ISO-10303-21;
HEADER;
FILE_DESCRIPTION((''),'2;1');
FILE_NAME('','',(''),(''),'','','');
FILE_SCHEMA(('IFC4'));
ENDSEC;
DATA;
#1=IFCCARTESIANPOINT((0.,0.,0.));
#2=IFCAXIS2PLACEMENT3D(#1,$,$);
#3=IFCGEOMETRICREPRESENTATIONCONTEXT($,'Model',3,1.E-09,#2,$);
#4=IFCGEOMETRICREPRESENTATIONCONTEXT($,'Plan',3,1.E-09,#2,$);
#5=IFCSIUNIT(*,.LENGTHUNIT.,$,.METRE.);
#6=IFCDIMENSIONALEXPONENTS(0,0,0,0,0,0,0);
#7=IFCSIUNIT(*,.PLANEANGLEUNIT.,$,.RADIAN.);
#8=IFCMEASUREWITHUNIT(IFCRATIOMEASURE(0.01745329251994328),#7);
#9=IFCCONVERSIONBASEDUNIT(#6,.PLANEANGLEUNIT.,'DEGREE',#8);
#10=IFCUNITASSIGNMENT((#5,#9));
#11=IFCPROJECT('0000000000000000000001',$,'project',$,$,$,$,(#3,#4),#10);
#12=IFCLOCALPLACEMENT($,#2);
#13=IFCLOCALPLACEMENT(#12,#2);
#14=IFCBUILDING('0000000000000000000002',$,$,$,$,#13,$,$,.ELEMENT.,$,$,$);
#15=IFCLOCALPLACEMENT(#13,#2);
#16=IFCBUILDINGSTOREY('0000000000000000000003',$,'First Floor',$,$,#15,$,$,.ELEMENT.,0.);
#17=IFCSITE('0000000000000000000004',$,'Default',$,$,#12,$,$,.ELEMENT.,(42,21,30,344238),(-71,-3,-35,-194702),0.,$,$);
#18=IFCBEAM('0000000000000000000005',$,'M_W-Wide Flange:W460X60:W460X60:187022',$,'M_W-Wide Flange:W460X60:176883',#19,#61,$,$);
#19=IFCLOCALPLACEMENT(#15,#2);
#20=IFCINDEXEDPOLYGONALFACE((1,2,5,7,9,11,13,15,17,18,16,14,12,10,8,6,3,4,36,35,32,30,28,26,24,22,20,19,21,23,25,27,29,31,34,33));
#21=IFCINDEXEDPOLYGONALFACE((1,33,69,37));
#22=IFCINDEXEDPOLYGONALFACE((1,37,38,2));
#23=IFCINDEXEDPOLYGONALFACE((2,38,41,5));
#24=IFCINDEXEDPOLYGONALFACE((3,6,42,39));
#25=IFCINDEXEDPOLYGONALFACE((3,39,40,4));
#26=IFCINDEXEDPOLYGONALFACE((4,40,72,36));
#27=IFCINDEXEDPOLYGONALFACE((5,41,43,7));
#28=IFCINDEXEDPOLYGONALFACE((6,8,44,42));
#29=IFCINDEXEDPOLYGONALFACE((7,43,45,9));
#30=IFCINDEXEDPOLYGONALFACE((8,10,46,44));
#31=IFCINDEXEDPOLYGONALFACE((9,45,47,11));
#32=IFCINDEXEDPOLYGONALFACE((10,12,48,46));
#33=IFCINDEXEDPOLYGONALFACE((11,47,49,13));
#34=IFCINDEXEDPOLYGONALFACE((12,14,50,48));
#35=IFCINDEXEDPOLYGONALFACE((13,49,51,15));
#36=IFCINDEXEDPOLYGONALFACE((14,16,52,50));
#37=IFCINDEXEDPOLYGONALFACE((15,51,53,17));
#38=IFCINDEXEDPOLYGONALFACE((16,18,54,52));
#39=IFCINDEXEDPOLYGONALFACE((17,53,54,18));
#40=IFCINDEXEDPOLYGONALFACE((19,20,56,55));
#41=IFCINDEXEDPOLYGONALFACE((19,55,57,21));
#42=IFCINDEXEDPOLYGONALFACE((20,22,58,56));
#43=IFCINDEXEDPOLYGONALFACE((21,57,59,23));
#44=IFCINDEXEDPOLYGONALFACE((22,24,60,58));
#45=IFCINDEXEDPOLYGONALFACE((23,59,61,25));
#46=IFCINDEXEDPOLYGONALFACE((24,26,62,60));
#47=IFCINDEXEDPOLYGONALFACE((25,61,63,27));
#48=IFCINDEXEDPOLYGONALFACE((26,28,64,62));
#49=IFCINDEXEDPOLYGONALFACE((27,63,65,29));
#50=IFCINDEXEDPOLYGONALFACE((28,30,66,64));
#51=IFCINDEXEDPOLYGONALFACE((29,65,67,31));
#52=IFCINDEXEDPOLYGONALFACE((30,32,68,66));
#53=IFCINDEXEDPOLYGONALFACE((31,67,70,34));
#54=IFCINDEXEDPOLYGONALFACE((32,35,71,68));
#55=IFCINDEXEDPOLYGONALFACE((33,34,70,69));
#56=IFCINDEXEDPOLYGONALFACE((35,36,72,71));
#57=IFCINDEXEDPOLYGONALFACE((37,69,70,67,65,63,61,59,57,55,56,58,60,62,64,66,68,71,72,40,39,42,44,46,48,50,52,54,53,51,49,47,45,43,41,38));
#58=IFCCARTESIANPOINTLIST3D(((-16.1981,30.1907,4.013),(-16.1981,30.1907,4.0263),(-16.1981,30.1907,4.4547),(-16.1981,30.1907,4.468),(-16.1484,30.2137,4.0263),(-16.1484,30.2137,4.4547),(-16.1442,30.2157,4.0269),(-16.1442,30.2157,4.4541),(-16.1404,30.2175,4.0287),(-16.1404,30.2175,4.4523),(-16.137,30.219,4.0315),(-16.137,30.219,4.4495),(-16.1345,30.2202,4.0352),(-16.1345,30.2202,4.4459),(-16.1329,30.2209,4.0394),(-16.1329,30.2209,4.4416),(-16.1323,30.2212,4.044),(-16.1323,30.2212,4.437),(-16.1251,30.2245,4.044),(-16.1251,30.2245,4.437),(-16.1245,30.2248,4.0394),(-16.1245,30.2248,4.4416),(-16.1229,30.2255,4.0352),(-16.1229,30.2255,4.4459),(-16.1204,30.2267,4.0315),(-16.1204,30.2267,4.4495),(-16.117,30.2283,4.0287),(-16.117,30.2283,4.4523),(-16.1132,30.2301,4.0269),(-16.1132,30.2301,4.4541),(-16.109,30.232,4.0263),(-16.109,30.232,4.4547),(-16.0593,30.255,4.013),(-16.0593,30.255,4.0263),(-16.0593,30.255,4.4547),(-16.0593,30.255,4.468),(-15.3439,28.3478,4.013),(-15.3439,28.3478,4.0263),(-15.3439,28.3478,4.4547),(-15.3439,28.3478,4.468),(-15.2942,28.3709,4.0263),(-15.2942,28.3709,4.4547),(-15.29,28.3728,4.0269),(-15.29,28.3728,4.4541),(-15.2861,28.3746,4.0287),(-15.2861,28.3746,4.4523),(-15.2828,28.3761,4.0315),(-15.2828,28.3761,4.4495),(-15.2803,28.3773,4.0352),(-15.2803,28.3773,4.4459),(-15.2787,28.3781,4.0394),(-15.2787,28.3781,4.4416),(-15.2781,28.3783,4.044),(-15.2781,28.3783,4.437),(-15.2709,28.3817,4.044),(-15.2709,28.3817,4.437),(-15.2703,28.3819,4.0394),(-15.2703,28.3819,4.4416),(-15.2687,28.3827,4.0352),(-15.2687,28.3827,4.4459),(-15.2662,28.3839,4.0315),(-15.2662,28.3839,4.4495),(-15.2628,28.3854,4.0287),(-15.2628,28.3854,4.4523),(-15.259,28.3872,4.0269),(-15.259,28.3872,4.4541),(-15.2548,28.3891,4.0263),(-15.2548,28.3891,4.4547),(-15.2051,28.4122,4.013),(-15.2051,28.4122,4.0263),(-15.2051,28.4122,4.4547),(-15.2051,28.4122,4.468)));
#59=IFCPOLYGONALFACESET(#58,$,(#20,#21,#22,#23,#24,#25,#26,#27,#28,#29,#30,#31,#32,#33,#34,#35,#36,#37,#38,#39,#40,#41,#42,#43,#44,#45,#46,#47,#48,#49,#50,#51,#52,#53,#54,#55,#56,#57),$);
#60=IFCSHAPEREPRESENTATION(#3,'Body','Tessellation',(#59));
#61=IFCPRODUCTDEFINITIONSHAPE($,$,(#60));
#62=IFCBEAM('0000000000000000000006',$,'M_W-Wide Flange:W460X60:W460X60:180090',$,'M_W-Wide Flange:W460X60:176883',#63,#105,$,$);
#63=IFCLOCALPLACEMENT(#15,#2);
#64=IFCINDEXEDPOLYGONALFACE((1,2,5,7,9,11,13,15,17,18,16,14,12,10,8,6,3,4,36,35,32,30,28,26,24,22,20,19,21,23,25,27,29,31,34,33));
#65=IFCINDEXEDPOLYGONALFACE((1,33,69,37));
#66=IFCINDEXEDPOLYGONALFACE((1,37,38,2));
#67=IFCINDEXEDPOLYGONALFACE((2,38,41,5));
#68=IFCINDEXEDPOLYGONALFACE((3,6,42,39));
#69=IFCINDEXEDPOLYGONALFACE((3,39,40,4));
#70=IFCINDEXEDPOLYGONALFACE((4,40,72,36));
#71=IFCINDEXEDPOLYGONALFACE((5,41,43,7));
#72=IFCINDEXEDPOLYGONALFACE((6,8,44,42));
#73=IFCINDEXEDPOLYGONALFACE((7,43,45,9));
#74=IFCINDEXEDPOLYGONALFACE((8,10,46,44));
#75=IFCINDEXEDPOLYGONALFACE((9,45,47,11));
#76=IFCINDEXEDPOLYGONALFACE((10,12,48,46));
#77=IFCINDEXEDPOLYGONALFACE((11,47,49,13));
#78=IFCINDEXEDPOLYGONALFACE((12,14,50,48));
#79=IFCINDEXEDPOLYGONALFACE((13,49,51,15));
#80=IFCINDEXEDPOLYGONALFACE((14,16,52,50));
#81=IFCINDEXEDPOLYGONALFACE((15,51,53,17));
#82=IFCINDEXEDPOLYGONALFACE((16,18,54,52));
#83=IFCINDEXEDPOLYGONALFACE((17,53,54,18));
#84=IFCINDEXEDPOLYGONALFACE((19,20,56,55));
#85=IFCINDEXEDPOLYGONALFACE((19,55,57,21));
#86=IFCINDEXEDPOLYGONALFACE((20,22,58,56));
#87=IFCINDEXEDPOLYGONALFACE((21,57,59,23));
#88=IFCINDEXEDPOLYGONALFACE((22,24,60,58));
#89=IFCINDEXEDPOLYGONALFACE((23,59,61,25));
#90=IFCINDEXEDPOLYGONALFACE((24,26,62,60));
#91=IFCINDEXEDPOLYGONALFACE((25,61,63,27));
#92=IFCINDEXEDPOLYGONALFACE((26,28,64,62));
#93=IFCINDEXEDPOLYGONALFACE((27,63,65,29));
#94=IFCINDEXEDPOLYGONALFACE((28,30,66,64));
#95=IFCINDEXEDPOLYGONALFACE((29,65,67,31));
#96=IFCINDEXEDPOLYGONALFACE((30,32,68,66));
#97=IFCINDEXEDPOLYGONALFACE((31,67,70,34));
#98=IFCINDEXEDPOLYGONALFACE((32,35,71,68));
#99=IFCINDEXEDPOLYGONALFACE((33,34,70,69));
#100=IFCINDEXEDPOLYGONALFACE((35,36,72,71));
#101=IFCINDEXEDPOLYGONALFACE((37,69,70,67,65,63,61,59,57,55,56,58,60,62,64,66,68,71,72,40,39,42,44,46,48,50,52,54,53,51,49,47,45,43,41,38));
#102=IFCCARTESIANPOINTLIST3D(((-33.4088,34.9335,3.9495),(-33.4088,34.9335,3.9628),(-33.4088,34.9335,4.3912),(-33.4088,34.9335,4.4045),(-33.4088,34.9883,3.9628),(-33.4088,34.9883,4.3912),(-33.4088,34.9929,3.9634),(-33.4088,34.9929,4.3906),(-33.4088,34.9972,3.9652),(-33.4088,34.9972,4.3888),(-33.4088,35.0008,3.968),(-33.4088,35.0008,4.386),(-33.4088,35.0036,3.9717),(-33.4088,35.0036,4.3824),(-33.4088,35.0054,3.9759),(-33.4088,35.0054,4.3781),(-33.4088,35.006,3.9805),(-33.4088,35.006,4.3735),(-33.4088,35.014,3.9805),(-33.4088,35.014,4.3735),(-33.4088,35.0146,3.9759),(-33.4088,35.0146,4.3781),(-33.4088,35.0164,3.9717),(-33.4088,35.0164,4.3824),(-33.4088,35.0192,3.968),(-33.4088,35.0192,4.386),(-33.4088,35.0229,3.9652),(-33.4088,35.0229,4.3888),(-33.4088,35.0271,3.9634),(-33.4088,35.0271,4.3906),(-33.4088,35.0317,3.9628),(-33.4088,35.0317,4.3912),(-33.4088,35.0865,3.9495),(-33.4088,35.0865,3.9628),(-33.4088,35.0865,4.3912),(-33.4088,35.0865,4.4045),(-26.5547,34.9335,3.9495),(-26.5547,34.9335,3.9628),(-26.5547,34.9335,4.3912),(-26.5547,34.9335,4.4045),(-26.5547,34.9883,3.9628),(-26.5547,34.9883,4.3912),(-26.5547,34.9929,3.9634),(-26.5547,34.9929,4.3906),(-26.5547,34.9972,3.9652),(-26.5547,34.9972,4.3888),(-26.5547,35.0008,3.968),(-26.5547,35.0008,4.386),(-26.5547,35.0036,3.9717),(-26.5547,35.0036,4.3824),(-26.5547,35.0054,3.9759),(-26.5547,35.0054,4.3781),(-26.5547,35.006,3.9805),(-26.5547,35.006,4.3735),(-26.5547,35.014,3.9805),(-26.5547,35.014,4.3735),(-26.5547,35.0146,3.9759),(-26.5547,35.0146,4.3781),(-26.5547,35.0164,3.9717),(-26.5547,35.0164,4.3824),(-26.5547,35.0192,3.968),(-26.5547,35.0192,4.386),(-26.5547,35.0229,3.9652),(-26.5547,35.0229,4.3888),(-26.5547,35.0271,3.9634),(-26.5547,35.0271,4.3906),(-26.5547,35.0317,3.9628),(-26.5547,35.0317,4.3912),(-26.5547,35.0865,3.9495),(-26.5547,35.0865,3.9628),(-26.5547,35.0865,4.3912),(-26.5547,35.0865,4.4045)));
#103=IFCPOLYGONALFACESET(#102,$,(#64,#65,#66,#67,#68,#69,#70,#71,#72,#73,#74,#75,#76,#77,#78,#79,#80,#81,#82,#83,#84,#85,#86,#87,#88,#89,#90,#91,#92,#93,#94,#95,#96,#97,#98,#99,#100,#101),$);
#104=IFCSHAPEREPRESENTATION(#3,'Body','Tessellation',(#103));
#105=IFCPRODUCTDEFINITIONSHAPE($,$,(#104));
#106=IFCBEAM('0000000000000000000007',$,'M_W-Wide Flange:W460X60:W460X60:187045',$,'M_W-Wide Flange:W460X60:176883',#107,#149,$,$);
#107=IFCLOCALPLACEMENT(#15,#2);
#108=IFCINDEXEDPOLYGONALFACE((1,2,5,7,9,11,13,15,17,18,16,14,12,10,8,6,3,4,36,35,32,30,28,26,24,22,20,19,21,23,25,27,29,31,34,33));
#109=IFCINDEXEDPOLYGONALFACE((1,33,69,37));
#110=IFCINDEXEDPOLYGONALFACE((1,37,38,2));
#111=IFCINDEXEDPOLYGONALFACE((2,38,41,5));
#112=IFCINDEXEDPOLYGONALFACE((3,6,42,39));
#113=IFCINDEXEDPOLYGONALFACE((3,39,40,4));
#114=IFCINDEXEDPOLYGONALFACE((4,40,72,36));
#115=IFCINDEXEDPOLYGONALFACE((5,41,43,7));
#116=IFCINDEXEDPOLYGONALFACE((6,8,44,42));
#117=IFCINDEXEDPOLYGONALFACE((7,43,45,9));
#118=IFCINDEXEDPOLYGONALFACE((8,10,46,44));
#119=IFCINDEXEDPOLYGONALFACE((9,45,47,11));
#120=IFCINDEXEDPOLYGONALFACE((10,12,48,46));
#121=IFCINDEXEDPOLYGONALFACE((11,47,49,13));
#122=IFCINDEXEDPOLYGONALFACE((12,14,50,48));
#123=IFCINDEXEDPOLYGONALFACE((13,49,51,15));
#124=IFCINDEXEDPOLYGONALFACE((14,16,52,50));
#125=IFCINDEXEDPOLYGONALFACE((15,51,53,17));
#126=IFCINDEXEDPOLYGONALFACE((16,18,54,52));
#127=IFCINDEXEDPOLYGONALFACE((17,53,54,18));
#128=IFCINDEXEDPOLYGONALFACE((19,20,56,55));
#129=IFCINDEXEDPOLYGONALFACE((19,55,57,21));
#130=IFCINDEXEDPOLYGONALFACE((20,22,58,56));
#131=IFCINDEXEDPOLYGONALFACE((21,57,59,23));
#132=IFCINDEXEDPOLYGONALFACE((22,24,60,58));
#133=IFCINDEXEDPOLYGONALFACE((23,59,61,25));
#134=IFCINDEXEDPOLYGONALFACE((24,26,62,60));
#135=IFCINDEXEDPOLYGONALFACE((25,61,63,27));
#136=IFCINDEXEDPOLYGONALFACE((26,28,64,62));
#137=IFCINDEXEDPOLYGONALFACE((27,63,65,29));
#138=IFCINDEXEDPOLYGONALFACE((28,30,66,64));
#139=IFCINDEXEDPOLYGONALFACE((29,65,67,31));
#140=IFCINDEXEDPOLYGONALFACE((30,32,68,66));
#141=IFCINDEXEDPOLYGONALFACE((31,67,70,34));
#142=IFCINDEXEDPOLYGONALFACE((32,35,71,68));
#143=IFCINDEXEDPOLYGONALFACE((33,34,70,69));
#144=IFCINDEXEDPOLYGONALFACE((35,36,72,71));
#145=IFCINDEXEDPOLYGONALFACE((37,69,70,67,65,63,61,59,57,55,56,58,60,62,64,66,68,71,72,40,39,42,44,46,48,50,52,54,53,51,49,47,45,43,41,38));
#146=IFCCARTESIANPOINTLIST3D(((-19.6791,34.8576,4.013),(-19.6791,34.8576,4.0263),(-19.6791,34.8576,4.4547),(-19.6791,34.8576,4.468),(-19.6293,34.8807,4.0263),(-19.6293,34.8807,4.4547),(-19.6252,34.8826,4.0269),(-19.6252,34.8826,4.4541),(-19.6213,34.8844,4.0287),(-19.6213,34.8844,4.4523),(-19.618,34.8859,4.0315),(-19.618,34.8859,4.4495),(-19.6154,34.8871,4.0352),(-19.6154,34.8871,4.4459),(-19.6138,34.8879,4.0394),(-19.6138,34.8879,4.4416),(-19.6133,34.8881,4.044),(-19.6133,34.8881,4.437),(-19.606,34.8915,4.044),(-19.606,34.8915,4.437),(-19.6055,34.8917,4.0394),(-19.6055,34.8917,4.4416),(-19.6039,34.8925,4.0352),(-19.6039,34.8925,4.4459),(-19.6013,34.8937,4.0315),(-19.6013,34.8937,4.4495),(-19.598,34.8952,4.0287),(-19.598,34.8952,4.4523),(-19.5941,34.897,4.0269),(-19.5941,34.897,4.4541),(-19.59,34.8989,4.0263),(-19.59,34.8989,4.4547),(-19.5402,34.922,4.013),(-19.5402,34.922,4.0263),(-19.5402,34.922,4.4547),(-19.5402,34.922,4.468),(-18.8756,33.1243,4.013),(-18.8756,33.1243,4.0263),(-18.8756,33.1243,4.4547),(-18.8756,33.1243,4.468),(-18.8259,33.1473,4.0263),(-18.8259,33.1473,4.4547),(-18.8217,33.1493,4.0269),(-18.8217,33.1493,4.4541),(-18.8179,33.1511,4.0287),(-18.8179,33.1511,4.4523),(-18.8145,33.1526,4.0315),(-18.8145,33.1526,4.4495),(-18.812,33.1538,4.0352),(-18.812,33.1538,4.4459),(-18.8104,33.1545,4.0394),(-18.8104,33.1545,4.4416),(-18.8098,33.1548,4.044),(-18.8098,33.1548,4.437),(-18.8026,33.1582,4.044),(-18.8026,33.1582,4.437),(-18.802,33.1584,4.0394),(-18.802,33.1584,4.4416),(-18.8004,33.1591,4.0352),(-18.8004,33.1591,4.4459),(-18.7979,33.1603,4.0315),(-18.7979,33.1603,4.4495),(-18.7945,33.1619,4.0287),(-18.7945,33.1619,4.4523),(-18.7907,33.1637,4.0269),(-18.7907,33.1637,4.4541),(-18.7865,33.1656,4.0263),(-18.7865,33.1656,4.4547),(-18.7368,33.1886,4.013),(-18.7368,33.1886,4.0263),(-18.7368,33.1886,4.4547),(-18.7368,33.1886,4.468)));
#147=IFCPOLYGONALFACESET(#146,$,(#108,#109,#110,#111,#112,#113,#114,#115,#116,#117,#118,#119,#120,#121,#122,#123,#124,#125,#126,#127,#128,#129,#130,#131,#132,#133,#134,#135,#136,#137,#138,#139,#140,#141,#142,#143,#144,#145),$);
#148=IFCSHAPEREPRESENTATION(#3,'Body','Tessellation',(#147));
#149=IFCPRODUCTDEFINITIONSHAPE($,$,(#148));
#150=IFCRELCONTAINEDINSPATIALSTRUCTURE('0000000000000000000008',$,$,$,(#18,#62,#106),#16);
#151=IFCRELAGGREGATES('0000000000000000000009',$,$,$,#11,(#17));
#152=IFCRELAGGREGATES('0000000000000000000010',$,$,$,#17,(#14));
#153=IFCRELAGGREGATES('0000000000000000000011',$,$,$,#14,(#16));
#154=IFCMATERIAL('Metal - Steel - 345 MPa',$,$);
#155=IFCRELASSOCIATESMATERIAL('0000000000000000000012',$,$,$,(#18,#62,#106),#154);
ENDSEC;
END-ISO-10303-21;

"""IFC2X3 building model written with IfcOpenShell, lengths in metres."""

from ifc_helpers import new_model, entity, si_unit, converted_unit, frame, frame_2d, origin, place, context, project, spatial, polyline, circle_curve, parameter, trimmed, segment, composite_curve, outline, extrude, material, element, save


model = new_model("IFC2X3")

# Units and contexts
model_context = context("Model", 3, precision=1e-09, world=origin())
plan_context = context("Plan", 3, precision=1e-09, world=origin())
ifc_project = project(units=[si_unit("LENGTHUNIT", "METRE"), converted_unit("PLANEANGLEUNIT", "DEGREE", entity("IfcRatioMeasure", 0.01745329251994328), si_unit("PLANEANGLEUNIT", "RADIAN"), dimensions=[0, 0, 0, 0, 0, 0, 0])], contexts=[model_context, plan_context])

# Site, building, storey
site_placement = place(None, origin())
site = spatial("IfcSite", under=ifc_project, at=site_placement, Name="Default", CompositionType="ELEMENT", RefLatitude=(42, 21, 30, 344238), RefLongitude=(-71, -3, -35, -194702), RefElevation=0.0)
building_placement = place(site_placement, origin())
building = spatial("IfcBuilding", under=site, at=building_placement, CompositionType="ELEMENT")
storey_placement = place(building_placement, origin())
storey = spatial("IfcBuildingStorey", under=building, at=storey_placement, Name="First Floor", CompositionType="ELEMENT", Elevation=0.0)

# Shared definitions
ifc_material = material(Name="Metal - Steel - 345 MPa")

# Beams
beam_1_placement = place(storey_placement, frame((-16.2175, 30.4144, 4.468), z_axis=(0.0, 0.0, 1.0), x_axis=(-0.907271, -0.420546, 0.0)))
element("IfcBeam", 1, at=beam_1_placement, inside=storey, material=ifc_material, Name="M_W-Wide Flange:W460X60:W460X60:187022", ObjectType="M_W-Wide Flange:W460X60:176883", context=model_context, shape_type="SweptSolid", body=[
    extrude(outline(composite_curve([segment(polyline([(0.2142, -0.0765), (0.2275, -0.0765)]), True, "CONTINUOUS"), segment(polyline([(0.2275, -0.0765), (0.2275, 0.0765)]), True, "CONTINUOUS"), segment(polyline([(0.2275, 0.0765), (0.2142, 0.0765)]), True, "CONTINUOUS"), segment(polyline([(0.2142, 0.0765), (0.2142, 0.0217)]), True, "CONTINUOUS"), segment(trimmed(circle_curve(frame_2d((0.1965, 0.0217), x_axis=(0.0, 1.0)), 0.0177), [parameter(180.0)], [parameter(270.0)], True, "PARAMETER"), False, "CONTINUOUS"), segment(polyline([(0.1965, 0.004), (-0.1965, 0.004)]), True, "CONTINUOUS"), segment(trimmed(circle_curve(frame_2d((-0.1965, 0.0217), x_axis=(0.0, 1.0)), 0.0177), [parameter(90.0)], [parameter(180.0)], True, "PARAMETER"), False, "CONTINUOUS"), segment(polyline([(-0.2142, 0.0217), (-0.2142, 0.0765)]), True, "CONTINUOUS"), segment(polyline([(-0.2142, 0.0765), (-0.2275, 0.0765)]), True, "CONTINUOUS"), segment(polyline([(-0.2275, 0.0765), (-0.2275, -0.0765)]), True, "CONTINUOUS"), segment(polyline([(-0.2275, -0.0765), (-0.2142, -0.0765)]), True, "CONTINUOUS"), segment(polyline([(-0.2142, -0.0765), (-0.2142, -0.0217)]), True, "CONTINUOUS"), segment(trimmed(circle_curve(frame_2d((-0.1965, -0.0217), x_axis=(0.0, 1.0)), 0.0177), [parameter(360.0)], [parameter(90.0)], True, "PARAMETER"), False, "CONTINUOUS"), segment(polyline([(-0.1965, -0.004), (0.1965, -0.004)]), True, "CONTINUOUS"), segment(trimmed(circle_curve(frame_2d((0.1965, -0.0217), x_axis=(0.0, 1.0)), 0.0177), [parameter(270.0)], [parameter(0.0)], True, "PARAMETER"), False, "CONTINUOUS"), segment(polyline([(0.2142, -0.0217), (0.2142, -0.0765)]), True, "CONTINUOUS")], self_intersect=False)), frame((0.0, 2.2423, -0.2275), z_axis=(0.0, -1.0, 0.0), x_axis=(0.0, 0.0, -1.0)), (0.0, 0.0, 1.0), 2.0312),
])
beam_2_placement = place(storey_placement, frame((-26.4381, 35.01, 4.4045), z_axis=(0.0, 0.0, 1.0), x_axis=(0.0, 1.0, 0.0)))
element("IfcBeam", 2, at=beam_2_placement, inside=storey, material=ifc_material, Name="M_W-Wide Flange:W460X60:W460X60:180090", ObjectType="M_W-Wide Flange:W460X60:176883", context=model_context, shape_type="SweptSolid", body=[
    extrude(outline(composite_curve([segment(polyline([(0.2142, -0.0765), (0.2275, -0.0765)]), True, "CONTINUOUS"), segment(polyline([(0.2275, -0.0765), (0.2275, 0.0765)]), True, "CONTINUOUS"), segment(polyline([(0.2275, 0.0765), (0.2142, 0.0765)]), True, "CONTINUOUS"), segment(polyline([(0.2142, 0.0765), (0.2142, 0.0217)]), True, "CONTINUOUS"), segment(trimmed(circle_curve(frame_2d((0.1965, 0.0217), x_axis=(1.0, 0.0)), 0.0177), [parameter(270.0)], [parameter(360.0)], True, "PARAMETER"), False, "CONTINUOUS"), segment(polyline([(0.1965, 0.004), (-0.1965, 0.004)]), True, "CONTINUOUS"), segment(trimmed(circle_curve(frame_2d((-0.1965, 0.0217), x_axis=(0.0, -1.0)), 0.0177), [parameter(270.0)], [parameter(360.0)], True, "PARAMETER"), False, "CONTINUOUS"), segment(polyline([(-0.2142, 0.0217), (-0.2142, 0.0765)]), True, "CONTINUOUS"), segment(polyline([(-0.2142, 0.0765), (-0.2275, 0.0765)]), True, "CONTINUOUS"), segment(polyline([(-0.2275, 0.0765), (-0.2275, -0.0765)]), True, "CONTINUOUS"), segment(polyline([(-0.2275, -0.0765), (-0.2142, -0.0765)]), True, "CONTINUOUS"), segment(polyline([(-0.2142, -0.0765), (-0.2142, -0.0217)]), True, "CONTINUOUS"), segment(trimmed(circle_curve(frame_2d((-0.1965, -0.0217), x_axis=(-1.0, 0.0)), 0.0177), [parameter(270.0)], [parameter(360.0)], True, "PARAMETER"), False, "CONTINUOUS"), segment(polyline([(-0.1965, -0.004), (0.1965, -0.004)]), True, "CONTINUOUS"), segment(trimmed(circle_curve(frame_2d((0.1965, -0.0217), x_axis=(0.0, 1.0)), 0.0177), [parameter(270.0)], [parameter(0.0)], True, "PARAMETER"), False, "CONTINUOUS"), segment(polyline([(0.2142, -0.0217), (0.2142, -0.0765)]), True, "CONTINUOUS")], self_intersect=False)), frame((0.0, 6.9707, -0.2275), z_axis=(0.0, -1.0, 0.0), x_axis=(0.0, 0.0, -1.0)), (0.0, 0.0, 1.0), 6.8541),
])
beam_3_placement = place(storey_placement, frame((-18.7221, 32.975, 4.468), z_axis=(0.0, 0.0, 1.0), x_axis=(0.907271, 0.420546, 0.0)))
element("IfcBeam", 3, at=beam_3_placement, inside=storey, material=ifc_material, Name="M_W-Wide Flange:W460X60:W460X60:187045", ObjectType="M_W-Wide Flange:W460X60:176883", context=model_context, shape_type="SweptSolid", body=[
    extrude(outline(composite_curve([segment(polyline([(-0.0765, -0.2142), (-0.0765, -0.2275)]), True, "CONTINUOUS"), segment(polyline([(-0.0765, -0.2275), (0.0765, -0.2275)]), True, "CONTINUOUS"), segment(polyline([(0.0765, -0.2275), (0.0765, -0.2142)]), True, "CONTINUOUS"), segment(polyline([(0.0765, -0.2142), (0.0217, -0.2142)]), True, "CONTINUOUS"), segment(trimmed(circle_curve(frame_2d((0.0217, -0.1965), x_axis=(1.0, 0.0)), 0.0177), [parameter(180.0)], [parameter(270.0)], True, "PARAMETER"), False, "CONTINUOUS"), segment(polyline([(0.004, -0.1965), (0.004, 0.1965)]), True, "CONTINUOUS"), segment(trimmed(circle_curve(frame_2d((0.0217, 0.1965), x_axis=(1.0, 0.0)), 0.0177), [parameter(90.0)], [parameter(180.0)], True, "PARAMETER"), False, "CONTINUOUS"), segment(polyline([(0.0217, 0.2142), (0.0765, 0.2142)]), True, "CONTINUOUS"), segment(polyline([(0.0765, 0.2142), (0.0765, 0.2275)]), True, "CONTINUOUS"), segment(polyline([(0.0765, 0.2275), (-0.0765, 0.2275)]), True, "CONTINUOUS"), segment(polyline([(-0.0765, 0.2275), (-0.0765, 0.2142)]), True, "CONTINUOUS"), segment(polyline([(-0.0765, 0.2142), (-0.0217, 0.2142)]), True, "CONTINUOUS"), segment(trimmed(circle_curve(frame_2d((-0.0217, 0.1965), x_axis=(1.0, 0.0)), 0.0177), [parameter(360.0)], [parameter(90.0)], True, "PARAMETER"), False, "CONTINUOUS"), segment(polyline([(-0.004, 0.1965), (-0.004, -0.1965)]), True, "CONTINUOUS"), segment(trimmed(circle_curve(frame_2d((-0.0217, -0.1965), x_axis=(1.0, 0.0)), 0.0177), [parameter(270.0)], [parameter(0.0)], True, "PARAMETER"), False, "CONTINUOUS"), segment(polyline([(-0.0217, -0.2142), (-0.0765, -0.2142)]), True, "CONTINUOUS")], self_intersect=False)), frame((0.0, 0.2, -0.2275), z_axis=(0.0, -1.0, 0.0), x_axis=(1.0, 0.0, 0.0)), (0.0, 0.0, -1.0), 1.9105),
])

save(model, "model.ifc")
